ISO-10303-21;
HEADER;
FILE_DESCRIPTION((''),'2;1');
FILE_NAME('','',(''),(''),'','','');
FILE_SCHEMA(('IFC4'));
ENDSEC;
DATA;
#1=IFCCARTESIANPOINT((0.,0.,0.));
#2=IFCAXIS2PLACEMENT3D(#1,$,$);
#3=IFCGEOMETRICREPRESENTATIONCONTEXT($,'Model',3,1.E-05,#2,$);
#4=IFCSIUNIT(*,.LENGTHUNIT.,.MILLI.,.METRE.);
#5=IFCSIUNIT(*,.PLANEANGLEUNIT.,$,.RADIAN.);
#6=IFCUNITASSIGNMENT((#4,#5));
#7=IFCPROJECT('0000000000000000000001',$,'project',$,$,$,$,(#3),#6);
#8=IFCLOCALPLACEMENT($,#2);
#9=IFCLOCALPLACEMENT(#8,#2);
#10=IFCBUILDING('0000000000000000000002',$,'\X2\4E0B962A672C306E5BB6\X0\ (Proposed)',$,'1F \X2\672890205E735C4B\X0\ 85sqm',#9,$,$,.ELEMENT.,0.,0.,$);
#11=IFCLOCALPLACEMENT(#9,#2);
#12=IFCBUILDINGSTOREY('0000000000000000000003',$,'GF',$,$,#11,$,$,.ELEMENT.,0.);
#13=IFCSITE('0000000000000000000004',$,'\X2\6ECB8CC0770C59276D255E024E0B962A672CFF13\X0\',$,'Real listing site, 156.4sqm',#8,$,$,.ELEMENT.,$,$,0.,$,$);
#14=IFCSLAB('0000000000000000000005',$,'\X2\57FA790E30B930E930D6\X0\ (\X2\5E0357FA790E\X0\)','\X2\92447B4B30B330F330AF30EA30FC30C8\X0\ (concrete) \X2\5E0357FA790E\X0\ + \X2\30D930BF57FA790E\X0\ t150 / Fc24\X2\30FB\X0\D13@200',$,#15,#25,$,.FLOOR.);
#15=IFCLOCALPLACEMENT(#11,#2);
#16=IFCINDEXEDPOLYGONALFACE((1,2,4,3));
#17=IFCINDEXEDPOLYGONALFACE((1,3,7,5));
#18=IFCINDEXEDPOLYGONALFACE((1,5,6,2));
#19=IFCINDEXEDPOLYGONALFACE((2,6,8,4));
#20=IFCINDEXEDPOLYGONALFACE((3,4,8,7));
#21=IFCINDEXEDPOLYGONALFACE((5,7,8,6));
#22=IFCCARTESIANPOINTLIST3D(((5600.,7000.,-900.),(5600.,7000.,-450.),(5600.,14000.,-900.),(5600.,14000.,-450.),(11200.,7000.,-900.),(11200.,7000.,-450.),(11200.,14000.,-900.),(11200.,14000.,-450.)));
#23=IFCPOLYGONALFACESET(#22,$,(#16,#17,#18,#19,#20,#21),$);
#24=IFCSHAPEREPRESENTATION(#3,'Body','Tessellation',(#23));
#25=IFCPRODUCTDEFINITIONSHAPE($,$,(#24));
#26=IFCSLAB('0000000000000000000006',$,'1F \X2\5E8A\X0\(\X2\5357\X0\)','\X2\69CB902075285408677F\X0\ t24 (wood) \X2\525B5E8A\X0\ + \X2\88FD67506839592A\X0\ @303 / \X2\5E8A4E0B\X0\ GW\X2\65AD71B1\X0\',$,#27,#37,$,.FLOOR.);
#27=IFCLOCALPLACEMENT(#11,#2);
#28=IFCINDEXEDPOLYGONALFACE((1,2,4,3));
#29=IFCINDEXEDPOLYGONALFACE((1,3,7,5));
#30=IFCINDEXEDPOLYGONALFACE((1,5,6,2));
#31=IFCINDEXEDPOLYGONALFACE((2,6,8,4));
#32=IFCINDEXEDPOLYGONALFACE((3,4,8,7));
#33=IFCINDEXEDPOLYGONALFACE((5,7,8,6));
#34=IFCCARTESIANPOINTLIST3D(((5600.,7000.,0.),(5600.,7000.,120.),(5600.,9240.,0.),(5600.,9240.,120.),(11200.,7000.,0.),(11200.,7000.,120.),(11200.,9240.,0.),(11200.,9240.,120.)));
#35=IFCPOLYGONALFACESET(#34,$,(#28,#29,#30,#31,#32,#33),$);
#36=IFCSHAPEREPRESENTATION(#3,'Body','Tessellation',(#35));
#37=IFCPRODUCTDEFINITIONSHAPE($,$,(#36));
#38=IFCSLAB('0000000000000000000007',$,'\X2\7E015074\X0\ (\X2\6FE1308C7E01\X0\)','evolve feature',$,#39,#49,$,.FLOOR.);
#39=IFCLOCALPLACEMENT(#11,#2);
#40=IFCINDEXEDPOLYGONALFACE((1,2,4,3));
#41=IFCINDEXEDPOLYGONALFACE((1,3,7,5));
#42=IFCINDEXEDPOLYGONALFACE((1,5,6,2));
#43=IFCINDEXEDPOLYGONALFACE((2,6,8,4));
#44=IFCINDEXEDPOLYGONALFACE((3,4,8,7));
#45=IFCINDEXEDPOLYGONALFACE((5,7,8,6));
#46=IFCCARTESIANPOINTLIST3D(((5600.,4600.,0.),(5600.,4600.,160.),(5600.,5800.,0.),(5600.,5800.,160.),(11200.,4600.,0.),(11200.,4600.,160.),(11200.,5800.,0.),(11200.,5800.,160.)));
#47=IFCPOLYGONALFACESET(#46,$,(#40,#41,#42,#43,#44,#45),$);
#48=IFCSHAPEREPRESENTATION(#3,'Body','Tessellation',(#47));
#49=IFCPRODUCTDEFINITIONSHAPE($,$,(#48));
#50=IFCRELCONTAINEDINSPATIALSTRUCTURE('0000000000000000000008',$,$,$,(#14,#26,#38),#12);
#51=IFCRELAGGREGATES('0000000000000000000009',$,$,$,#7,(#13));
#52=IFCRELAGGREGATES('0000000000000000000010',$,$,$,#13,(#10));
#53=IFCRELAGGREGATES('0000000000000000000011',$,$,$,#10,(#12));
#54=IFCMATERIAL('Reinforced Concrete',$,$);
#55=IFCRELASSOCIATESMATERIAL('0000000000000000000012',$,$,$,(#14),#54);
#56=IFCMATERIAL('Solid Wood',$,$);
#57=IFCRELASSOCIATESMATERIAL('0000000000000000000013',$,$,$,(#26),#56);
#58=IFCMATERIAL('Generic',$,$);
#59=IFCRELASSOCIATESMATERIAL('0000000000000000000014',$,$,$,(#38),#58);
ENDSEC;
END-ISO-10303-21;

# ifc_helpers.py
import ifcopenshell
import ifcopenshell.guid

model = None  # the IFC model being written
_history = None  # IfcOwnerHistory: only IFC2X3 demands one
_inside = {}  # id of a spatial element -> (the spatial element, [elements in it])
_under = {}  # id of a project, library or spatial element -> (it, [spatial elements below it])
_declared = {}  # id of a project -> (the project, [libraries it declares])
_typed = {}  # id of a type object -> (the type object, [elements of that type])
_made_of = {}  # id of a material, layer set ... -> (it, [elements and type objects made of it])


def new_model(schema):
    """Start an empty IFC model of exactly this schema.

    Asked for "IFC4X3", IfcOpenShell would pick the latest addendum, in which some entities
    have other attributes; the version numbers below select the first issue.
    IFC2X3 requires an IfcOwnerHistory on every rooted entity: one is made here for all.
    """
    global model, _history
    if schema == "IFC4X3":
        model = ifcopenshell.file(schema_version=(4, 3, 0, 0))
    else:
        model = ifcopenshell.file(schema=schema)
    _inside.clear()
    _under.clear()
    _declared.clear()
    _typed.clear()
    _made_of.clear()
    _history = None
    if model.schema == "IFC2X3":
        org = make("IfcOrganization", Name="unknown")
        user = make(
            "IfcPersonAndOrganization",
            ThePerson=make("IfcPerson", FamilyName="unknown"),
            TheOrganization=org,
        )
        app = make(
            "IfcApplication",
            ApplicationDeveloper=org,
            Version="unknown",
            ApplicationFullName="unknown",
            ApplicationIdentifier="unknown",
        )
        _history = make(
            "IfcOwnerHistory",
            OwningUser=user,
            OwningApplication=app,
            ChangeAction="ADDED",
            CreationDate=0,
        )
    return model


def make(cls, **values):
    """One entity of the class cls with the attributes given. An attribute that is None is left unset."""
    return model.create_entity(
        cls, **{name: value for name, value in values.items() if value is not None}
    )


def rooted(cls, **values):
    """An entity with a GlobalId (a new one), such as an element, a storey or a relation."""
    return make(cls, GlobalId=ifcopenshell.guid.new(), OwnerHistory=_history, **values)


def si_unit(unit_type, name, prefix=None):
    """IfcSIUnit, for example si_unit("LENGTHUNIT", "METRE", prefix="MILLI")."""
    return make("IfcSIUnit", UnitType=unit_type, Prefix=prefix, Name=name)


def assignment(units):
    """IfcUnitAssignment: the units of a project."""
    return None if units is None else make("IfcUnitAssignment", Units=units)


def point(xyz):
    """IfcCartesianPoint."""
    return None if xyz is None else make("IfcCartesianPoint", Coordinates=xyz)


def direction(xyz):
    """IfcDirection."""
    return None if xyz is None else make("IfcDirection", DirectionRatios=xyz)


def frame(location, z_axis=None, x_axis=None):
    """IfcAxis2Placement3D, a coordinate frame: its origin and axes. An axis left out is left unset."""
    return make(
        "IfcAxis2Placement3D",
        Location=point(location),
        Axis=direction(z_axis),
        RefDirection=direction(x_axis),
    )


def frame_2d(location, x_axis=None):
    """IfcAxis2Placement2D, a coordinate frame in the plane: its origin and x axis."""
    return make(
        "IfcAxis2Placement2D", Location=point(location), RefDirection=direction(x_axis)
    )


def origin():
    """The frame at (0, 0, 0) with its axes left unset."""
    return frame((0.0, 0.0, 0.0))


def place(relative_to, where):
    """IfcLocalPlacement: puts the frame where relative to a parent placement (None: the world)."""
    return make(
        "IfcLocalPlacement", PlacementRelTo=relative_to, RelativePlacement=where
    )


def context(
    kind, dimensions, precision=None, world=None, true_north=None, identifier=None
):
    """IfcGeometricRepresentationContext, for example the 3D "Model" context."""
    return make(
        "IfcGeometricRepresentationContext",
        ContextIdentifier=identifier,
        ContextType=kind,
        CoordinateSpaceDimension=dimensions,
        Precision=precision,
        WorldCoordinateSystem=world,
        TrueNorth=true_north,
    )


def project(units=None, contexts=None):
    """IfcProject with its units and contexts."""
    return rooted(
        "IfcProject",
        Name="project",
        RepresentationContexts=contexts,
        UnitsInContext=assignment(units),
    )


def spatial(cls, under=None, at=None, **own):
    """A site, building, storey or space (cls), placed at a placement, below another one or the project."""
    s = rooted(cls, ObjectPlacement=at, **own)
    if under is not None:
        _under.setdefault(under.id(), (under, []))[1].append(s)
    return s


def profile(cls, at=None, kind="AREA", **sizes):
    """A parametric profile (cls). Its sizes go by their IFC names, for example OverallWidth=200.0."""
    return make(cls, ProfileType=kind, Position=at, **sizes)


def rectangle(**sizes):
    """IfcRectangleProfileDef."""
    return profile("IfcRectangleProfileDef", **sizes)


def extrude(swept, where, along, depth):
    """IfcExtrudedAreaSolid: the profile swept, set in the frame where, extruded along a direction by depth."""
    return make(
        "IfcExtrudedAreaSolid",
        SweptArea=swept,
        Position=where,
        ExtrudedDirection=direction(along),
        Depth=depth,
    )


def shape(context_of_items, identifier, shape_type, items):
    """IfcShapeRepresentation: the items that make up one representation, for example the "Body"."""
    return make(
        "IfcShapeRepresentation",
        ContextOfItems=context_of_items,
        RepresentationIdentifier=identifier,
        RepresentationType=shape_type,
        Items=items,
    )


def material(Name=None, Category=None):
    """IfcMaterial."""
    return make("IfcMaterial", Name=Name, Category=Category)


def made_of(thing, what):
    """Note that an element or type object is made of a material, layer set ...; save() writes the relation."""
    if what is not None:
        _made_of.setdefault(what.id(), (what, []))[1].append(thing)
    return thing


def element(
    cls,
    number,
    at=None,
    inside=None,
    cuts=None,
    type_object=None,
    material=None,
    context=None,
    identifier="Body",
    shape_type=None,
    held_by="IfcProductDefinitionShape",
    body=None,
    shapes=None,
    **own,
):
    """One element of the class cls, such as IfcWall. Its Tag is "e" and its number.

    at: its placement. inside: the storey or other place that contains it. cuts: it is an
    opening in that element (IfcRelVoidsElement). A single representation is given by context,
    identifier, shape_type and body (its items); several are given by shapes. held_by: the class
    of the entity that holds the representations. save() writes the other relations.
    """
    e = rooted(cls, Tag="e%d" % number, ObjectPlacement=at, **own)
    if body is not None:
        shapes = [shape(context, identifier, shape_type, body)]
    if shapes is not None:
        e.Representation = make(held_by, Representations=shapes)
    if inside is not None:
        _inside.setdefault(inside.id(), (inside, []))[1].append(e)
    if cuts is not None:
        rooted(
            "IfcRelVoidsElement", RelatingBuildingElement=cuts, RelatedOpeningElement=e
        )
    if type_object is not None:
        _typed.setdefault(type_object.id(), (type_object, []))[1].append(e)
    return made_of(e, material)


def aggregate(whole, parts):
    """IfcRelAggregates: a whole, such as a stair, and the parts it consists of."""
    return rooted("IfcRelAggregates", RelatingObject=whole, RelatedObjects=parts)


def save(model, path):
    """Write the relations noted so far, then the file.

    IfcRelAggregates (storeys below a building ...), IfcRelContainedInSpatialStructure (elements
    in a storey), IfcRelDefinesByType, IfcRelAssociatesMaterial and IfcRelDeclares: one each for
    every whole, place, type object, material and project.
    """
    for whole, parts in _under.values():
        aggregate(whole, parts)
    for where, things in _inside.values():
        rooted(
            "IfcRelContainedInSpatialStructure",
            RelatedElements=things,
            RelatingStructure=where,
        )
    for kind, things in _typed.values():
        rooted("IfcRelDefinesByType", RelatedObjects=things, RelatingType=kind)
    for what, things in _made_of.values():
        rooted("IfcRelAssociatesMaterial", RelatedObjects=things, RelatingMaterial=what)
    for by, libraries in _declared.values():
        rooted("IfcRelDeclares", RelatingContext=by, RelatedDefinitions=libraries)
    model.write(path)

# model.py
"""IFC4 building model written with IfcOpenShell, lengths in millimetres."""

from ifc_helpers import new_model, si_unit, frame, frame_2d, origin, place, context, project, spatial, rectangle, extrude, material, element, save


model = new_model("IFC4")

# Units and contexts
model_context = context("Model", 3, precision=1e-05, world=origin())
ifc_project = project(units=[si_unit("LENGTHUNIT", "METRE", prefix="MILLI"), si_unit("PLANEANGLEUNIT", "RADIAN")], contexts=[model_context])

# Site, building, storey
site_placement = place(None, origin())
site = spatial("IfcSite", under=ifc_project, at=site_placement, Name="滋賀県大津市下阪本３", ObjectType="Real listing site, 156.4sqm", CompositionType="ELEMENT", RefElevation=0.0)
building_placement = place(site_placement, origin())
building = spatial("IfcBuilding", under=site, at=building_placement, Name="下阪本の家 (Proposed)", ObjectType="1F 木造平屋 85sqm", CompositionType="ELEMENT", ElevationOfRefHeight=0.0, ElevationOfTerrain=0.0)
storey_placement = place(building_placement, origin())
storey = spatial("IfcBuildingStorey", under=building, at=storey_placement, Name="GF", CompositionType="ELEMENT", Elevation=0.0)

# Slabs
ifc_material_1 = material(Name="Reinforced Concrete")
slab_1_placement = place(storey_placement, frame((2800.0, 3500.0, -450.0)))
element("IfcSlab", 1, at=slab_1_placement, inside=storey, material=ifc_material_1, Name="基礎スラブ (布基礎)", Description="鉄筋コンクリート (concrete) 布基礎 + ベタ基礎 t150 / Fc24・D13@200", PredefinedType="FLOOR", context=model_context, shape_type="SweptSolid", body=[
    extrude(rectangle(XDim=5600.0, YDim=7000.0, at=frame_2d((2800.0, 3500.0))), frame((2800.0, 3500.0, -450.0)), (0.0, 0.0, 1.0), 450.0),
])
ifc_material_2 = material(Name="Solid Wood")
slab_2_placement = place(storey_placement, frame((2800.0, 3500.0, 0.0)))
element("IfcSlab", 2, at=slab_2_placement, inside=storey, material=ifc_material_2, Name="1F 床(南)", Description="構造用合板 t24 (wood) 剛床 + 製材根太 @303 / 床下 GW断熱", PredefinedType="FLOOR", context=model_context, shape_type="SweptSolid", body=[
    extrude(rectangle(XDim=5600.0, YDim=2240.0, at=frame_2d((2800.0, 1120.0))), frame((2800.0, 3500.0, 0.0)), (0.0, 0.0, 1.0), 120.0),
])
ifc_material_3 = material(Name="Generic")
slab_3_placement = place(storey_placement, frame((2800.0, 2300.0, 0.0)))
element("IfcSlab", 3, at=slab_3_placement, inside=storey, material=ifc_material_3, Name="縁側 (濡れ縁)", Description="evolve feature", PredefinedType="FLOOR", context=model_context, shape_type="SweptSolid", body=[
    extrude(rectangle(XDim=5600.0, YDim=1200.0, at=frame_2d((2800.0, 600.0))), frame((2800.0, 2300.0, 0.0)), (0.0, 0.0, 1.0), 160.0),
])

save(model, "model.ifc")
